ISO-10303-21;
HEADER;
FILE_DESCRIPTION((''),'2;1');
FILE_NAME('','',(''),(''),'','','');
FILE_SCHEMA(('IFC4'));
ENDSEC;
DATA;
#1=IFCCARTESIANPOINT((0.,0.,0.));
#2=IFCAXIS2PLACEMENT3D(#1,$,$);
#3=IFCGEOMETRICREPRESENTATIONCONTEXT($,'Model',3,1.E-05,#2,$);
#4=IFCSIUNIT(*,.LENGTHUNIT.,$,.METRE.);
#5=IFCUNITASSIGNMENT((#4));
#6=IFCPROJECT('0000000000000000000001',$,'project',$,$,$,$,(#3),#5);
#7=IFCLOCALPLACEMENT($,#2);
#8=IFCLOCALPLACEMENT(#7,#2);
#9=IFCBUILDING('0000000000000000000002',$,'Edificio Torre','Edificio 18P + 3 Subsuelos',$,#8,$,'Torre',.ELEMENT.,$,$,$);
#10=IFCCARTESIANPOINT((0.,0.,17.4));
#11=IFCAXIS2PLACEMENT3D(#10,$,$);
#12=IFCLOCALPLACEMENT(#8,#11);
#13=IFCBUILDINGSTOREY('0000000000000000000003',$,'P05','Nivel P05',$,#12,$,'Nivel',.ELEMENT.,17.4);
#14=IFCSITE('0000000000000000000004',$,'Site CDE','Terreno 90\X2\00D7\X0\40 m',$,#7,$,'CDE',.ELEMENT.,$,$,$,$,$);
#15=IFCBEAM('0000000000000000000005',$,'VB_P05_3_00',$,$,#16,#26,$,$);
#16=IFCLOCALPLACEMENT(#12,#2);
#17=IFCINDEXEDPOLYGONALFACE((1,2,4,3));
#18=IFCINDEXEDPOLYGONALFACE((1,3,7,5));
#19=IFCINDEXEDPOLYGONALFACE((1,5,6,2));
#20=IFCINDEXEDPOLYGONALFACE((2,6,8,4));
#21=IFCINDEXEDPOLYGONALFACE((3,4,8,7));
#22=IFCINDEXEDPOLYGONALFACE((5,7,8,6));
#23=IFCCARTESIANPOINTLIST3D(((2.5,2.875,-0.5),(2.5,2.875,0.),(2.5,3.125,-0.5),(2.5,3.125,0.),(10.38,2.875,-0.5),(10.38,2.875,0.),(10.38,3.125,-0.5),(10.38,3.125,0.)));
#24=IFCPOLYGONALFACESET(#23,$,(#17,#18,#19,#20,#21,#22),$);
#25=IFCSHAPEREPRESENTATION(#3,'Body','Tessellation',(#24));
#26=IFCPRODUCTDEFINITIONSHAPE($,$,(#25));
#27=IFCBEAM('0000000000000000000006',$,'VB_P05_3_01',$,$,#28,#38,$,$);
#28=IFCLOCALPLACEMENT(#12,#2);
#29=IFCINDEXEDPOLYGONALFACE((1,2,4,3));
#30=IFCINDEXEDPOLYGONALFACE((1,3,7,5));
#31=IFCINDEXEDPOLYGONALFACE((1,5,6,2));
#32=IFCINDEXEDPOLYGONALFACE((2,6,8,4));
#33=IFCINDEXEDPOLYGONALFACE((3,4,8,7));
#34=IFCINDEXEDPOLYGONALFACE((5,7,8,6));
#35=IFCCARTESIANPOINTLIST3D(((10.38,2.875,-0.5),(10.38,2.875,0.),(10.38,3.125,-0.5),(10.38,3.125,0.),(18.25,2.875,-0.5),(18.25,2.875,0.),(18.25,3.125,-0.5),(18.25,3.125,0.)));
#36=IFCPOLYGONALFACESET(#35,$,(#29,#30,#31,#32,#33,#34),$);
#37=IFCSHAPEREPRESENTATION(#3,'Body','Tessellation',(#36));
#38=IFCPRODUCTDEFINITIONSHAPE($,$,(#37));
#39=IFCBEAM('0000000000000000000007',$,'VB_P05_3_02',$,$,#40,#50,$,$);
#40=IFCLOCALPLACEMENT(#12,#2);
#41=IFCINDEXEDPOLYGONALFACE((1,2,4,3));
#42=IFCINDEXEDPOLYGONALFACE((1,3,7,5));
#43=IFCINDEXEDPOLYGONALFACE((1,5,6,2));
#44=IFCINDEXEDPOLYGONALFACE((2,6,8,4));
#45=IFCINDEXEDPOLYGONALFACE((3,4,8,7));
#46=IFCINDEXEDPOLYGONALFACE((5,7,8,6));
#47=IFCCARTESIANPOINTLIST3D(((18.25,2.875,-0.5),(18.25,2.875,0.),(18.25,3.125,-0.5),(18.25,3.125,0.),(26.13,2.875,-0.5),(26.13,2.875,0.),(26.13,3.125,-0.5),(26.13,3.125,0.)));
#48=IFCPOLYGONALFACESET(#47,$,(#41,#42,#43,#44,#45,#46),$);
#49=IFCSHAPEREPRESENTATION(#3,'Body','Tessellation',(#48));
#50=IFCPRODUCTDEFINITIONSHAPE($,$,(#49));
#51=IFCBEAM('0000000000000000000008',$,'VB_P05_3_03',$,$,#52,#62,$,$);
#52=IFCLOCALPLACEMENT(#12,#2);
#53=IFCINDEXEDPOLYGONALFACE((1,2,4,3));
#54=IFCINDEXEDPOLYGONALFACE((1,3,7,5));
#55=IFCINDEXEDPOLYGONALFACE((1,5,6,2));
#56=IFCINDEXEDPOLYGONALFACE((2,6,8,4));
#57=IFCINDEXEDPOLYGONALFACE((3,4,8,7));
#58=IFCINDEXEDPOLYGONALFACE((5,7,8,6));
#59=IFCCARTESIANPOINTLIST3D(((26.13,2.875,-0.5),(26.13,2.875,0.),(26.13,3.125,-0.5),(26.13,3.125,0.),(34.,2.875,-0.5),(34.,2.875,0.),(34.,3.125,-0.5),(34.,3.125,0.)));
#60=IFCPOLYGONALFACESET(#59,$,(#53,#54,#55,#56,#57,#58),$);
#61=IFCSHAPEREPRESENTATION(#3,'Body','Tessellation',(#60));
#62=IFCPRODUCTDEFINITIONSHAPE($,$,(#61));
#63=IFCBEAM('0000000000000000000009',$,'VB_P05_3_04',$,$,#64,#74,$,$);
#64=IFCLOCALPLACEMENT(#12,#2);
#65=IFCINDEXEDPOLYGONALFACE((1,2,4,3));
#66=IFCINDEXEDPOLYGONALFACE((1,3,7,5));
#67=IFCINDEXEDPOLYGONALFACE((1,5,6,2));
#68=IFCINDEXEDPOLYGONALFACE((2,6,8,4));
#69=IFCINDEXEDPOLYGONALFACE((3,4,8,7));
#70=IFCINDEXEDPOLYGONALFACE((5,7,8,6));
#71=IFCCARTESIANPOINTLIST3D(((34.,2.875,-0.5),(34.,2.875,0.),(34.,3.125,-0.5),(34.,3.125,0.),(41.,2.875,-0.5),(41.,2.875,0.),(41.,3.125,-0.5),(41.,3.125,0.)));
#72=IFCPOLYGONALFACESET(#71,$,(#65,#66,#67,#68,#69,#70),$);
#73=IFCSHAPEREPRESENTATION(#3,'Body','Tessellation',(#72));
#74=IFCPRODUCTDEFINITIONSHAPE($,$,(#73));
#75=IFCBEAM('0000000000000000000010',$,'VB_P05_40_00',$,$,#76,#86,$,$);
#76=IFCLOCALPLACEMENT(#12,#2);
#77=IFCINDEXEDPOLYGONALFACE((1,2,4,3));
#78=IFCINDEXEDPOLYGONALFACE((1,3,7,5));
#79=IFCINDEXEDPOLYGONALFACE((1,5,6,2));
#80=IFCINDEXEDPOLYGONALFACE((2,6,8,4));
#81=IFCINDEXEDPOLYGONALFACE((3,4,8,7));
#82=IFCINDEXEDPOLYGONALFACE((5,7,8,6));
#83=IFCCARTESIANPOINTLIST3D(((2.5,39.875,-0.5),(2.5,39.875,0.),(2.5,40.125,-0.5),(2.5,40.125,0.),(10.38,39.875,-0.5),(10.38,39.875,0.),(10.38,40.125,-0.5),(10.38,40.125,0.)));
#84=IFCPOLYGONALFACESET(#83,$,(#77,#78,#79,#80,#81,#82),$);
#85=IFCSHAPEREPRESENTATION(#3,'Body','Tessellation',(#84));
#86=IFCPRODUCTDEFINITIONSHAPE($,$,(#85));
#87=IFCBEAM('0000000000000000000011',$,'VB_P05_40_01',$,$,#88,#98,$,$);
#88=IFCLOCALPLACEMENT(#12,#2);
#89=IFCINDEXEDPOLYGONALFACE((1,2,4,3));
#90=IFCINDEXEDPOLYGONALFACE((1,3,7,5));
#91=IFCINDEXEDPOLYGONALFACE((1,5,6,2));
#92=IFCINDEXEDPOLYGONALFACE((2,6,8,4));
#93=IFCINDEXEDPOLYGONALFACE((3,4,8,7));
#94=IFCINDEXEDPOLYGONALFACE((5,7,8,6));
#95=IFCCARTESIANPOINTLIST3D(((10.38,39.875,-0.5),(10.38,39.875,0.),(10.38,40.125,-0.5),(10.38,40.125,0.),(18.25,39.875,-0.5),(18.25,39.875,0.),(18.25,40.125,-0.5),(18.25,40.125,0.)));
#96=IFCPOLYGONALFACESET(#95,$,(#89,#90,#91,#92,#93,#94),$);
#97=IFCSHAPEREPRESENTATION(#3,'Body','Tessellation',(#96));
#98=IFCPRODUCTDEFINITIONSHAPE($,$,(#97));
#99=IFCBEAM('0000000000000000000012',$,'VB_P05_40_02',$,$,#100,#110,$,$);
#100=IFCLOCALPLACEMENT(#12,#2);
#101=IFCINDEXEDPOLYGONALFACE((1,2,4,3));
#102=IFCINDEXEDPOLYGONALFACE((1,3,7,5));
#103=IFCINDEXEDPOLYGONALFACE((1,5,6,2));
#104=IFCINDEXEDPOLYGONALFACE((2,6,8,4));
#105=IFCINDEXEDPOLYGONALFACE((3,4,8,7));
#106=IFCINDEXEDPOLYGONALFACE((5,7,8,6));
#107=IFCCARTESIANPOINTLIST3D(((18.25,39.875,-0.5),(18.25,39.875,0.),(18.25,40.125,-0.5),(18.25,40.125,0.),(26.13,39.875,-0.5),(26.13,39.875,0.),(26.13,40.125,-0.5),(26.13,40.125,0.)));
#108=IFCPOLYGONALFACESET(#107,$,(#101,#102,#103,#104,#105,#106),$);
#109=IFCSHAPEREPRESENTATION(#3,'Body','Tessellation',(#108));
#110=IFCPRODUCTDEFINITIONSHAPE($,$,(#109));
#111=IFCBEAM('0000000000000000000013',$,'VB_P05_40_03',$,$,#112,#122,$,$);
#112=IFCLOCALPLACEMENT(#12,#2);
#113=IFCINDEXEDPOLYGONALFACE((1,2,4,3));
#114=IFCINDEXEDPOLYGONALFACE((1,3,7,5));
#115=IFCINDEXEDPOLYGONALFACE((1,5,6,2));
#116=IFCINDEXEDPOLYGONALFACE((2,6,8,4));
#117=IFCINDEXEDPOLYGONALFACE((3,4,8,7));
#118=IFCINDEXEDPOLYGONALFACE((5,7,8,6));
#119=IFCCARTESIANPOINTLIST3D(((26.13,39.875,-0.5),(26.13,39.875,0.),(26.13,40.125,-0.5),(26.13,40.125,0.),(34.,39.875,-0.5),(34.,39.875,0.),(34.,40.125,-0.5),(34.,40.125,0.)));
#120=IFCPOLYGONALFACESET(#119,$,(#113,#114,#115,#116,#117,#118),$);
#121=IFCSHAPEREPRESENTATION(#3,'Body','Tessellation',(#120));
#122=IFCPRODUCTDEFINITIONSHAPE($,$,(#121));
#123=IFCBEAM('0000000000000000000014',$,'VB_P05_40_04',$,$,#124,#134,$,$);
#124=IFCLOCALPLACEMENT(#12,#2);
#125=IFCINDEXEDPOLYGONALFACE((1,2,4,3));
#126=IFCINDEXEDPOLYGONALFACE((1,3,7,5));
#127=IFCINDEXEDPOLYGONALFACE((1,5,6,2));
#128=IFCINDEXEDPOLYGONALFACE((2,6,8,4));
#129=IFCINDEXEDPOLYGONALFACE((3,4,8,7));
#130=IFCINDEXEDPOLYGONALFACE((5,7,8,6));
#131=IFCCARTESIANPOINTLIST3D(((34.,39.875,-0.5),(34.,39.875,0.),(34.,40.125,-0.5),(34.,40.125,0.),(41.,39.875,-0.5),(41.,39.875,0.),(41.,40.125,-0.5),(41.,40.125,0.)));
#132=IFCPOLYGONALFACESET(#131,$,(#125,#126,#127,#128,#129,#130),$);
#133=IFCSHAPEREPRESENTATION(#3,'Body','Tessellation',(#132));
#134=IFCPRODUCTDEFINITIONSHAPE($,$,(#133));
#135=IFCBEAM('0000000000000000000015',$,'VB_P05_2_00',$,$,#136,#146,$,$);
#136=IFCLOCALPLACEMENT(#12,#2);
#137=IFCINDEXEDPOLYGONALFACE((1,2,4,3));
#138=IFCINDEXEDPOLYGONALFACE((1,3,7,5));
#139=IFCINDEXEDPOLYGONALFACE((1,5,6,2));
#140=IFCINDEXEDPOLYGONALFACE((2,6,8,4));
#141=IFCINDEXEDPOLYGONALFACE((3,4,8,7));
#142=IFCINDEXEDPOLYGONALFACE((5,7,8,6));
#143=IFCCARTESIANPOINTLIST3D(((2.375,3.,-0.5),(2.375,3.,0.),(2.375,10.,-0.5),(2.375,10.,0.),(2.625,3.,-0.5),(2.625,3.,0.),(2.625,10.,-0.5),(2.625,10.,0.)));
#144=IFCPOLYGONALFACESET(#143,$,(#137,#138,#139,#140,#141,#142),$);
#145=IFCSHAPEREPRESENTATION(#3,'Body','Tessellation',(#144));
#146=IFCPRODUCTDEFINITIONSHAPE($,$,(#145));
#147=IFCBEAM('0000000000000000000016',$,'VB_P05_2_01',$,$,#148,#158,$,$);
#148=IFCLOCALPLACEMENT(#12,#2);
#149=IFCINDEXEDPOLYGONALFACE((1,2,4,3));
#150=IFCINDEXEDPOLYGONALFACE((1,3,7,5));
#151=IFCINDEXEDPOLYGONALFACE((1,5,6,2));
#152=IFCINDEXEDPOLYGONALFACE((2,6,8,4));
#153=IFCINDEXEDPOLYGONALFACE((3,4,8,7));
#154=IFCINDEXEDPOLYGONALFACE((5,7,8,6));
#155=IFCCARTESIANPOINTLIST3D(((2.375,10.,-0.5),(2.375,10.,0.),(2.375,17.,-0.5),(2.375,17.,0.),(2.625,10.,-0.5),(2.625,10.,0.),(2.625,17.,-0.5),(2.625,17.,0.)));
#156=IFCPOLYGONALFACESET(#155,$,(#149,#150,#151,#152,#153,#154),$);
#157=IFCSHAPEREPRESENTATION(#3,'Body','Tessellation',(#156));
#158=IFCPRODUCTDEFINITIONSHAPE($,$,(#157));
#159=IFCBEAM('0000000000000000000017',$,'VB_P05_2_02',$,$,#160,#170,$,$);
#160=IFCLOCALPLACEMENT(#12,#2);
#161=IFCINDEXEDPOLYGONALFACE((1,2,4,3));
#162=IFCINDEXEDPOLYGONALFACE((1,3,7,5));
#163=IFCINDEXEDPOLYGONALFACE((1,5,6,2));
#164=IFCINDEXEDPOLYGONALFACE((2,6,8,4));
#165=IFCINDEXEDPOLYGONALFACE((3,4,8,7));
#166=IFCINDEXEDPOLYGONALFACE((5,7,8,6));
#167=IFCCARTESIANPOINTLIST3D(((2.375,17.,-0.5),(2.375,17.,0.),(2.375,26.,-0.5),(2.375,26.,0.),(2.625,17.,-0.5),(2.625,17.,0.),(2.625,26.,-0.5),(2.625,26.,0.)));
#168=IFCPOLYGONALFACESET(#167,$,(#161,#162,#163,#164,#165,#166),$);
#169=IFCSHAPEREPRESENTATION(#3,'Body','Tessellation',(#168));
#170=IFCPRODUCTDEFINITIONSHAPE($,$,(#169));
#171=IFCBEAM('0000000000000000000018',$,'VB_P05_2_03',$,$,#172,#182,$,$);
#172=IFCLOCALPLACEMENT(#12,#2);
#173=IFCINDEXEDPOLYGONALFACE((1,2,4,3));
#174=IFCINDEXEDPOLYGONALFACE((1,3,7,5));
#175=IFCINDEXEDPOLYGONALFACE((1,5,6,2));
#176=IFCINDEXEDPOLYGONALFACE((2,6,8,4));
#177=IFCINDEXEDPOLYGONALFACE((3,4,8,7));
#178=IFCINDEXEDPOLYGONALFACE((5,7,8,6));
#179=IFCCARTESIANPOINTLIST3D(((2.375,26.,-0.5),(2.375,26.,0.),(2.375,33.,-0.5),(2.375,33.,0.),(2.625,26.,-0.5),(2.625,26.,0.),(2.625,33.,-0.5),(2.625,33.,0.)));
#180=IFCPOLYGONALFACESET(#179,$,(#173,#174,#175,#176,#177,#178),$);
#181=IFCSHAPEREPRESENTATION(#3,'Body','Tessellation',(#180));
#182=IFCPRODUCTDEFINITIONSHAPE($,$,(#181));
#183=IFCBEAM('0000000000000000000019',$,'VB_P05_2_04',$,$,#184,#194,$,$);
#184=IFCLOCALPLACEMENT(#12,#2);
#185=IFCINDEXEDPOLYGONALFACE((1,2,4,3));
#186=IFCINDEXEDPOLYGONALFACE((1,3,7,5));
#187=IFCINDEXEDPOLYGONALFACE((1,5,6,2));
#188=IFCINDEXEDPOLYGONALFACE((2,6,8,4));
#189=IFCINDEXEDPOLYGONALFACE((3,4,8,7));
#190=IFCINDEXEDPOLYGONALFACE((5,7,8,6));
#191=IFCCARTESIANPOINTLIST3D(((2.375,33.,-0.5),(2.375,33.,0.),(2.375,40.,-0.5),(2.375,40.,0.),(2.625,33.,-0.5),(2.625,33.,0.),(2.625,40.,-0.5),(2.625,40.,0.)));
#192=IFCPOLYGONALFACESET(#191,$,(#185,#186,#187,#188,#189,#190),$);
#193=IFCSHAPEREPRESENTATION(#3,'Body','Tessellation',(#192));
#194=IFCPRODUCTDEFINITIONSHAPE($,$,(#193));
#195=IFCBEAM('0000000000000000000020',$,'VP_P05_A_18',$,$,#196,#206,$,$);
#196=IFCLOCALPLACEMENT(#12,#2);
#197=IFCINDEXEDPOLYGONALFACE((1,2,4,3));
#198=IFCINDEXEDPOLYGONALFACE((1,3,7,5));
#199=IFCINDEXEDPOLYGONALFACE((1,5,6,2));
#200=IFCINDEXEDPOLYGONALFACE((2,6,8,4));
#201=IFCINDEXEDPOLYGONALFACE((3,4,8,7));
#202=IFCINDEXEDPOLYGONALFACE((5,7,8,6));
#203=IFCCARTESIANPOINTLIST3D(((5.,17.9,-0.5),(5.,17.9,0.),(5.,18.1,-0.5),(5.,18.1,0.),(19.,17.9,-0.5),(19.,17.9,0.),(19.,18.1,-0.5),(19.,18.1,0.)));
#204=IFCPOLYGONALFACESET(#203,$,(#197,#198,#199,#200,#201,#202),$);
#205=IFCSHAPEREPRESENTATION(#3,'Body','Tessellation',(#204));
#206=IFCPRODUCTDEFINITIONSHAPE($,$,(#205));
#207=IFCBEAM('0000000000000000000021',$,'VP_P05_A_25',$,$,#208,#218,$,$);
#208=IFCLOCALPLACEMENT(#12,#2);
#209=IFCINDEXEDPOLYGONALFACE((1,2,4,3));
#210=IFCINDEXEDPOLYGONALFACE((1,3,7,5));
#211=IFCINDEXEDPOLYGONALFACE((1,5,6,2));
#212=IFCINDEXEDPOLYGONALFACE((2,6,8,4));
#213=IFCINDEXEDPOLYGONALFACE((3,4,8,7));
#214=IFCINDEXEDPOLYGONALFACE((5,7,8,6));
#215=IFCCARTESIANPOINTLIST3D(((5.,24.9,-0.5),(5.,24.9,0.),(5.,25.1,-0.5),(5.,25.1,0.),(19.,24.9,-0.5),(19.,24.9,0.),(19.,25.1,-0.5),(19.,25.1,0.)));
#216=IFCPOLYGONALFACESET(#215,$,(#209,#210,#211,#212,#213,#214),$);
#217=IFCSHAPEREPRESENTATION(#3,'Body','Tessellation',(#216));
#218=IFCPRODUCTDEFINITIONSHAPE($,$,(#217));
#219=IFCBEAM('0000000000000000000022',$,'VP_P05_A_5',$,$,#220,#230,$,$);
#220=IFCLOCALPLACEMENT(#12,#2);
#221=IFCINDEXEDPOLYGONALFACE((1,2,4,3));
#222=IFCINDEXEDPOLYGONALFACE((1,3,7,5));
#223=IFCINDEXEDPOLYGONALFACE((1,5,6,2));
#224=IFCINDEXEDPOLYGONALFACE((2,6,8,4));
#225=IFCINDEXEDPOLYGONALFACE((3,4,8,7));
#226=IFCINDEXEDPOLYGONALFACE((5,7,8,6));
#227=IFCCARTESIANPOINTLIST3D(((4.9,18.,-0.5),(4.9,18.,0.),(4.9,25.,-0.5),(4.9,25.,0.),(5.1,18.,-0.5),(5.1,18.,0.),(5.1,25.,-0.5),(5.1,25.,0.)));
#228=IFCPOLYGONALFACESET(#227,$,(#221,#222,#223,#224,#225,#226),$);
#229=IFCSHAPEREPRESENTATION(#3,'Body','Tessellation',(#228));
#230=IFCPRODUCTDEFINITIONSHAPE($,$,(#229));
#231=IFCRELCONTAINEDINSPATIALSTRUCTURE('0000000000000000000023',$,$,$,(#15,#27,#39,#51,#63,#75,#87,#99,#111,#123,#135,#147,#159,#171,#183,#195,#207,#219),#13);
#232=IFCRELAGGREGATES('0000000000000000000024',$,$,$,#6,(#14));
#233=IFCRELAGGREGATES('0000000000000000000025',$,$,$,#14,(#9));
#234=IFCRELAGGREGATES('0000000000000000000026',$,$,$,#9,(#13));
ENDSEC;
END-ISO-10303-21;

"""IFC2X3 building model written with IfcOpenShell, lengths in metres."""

from ifc_helpers import new_model, si_unit, frame, origin, origin_2d, place, context, project, spatial, rectangle, extrude, element, save


model = new_model("IFC2X3")

# Units and contexts
model_context = context("Model", 3, precision=1e-05, world=origin())
ifc_project = project(units=[si_unit("LENGTHUNIT", "METRE")], contexts=[model_context])

# Site, building, storey
site_placement = place(None, origin())
site = spatial("IfcSite", under=ifc_project, at=site_placement, Name="Site CDE", Description="Terreno 90×40 m", LongName="CDE", CompositionType="ELEMENT")
building_placement = place(site_placement, origin())
building = spatial("IfcBuilding", under=site, at=building_placement, Name="Edificio Torre", Description="Edificio 18P + 3 Subsuelos", LongName="Torre", CompositionType="ELEMENT")
storey_placement = place(building_placement, frame((0.0, 0.0, 17.4)))
storey = spatial("IfcBuildingStorey", under=building, at=storey_placement, Name="P05", Description="Nivel P05", LongName="Nivel", CompositionType="ELEMENT", Elevation=17.4)

# Beams
beam_1_placement = place(storey_placement, frame((6.44, 3.0, -0.5)))
element("IfcBeam", 1, at=beam_1_placement, inside=storey, Name="VB_P05_3_00", context=model_context, shape_type="SweptSolid", body=[
    extrude(rectangle(XDim=7.88, YDim=0.25, at=origin_2d()), origin(), (0.0, 0.0, 1.0), 0.5),
])
beam_2_placement = place(storey_placement, frame((14.315, 3.0, -0.5)))
element("IfcBeam", 2, at=beam_2_placement, inside=storey, Name="VB_P05_3_01", context=model_context, shape_type="SweptSolid", body=[
    extrude(rectangle(XDim=7.87, YDim=0.25, at=origin_2d()), origin(), (0.0, 0.0, 1.0), 0.5),
])
beam_3_placement = place(storey_placement, frame((22.19, 3.0, -0.5)))
element("IfcBeam", 3, at=beam_3_placement, inside=storey, Name="VB_P05_3_02", context=model_context, shape_type="SweptSolid", body=[
    extrude(rectangle(XDim=7.88, YDim=0.25, at=origin_2d()), origin(), (0.0, 0.0, 1.0), 0.5),
])
beam_4_placement = place(storey_placement, frame((30.065, 3.0, -0.5)))
element("IfcBeam", 4, at=beam_4_placement, inside=storey, Name="VB_P05_3_03", context=model_context, shape_type="SweptSolid", body=[
    extrude(rectangle(XDim=7.87, YDim=0.25, at=origin_2d()), origin(), (0.0, 0.0, 1.0), 0.5),
])
beam_5_placement = place(storey_placement, frame((37.5, 3.0, -0.5)))
element("IfcBeam", 5, at=beam_5_placement, inside=storey, Name="VB_P05_3_04", context=model_context, shape_type="SweptSolid", body=[
    extrude(rectangle(XDim=7.0, YDim=0.25, at=origin_2d()), origin(), (0.0, 0.0, 1.0), 0.5),
])
beam_6_placement = place(storey_placement, frame((6.44, 40.0, -0.5)))
element("IfcBeam", 6, at=beam_6_placement, inside=storey, Name="VB_P05_40_00", context=model_context, shape_type="SweptSolid", body=[
    extrude(rectangle(XDim=7.88, YDim=0.25, at=origin_2d()), origin(), (0.0, 0.0, 1.0), 0.5),
])
beam_7_placement = place(storey_placement, frame((14.315, 40.0, -0.5)))
element("IfcBeam", 7, at=beam_7_placement, inside=storey, Name="VB_P05_40_01", context=model_context, shape_type="SweptSolid", body=[
    extrude(rectangle(XDim=7.87, YDim=0.25, at=origin_2d()), origin(), (0.0, 0.0, 1.0), 0.5),
])
beam_8_placement = place(storey_placement, frame((22.19, 40.0, -0.5)))
element("IfcBeam", 8, at=beam_8_placement, inside=storey, Name="VB_P05_40_02", context=model_context, shape_type="SweptSolid", body=[
    extrude(rectangle(XDim=7.88, YDim=0.25, at=origin_2d()), origin(), (0.0, 0.0, 1.0), 0.5),
])
beam_9_placement = place(storey_placement, frame((30.065, 40.0, -0.5)))
element("IfcBeam", 9, at=beam_9_placement, inside=storey, Name="VB_P05_40_03", context=model_context, shape_type="SweptSolid", body=[
    extrude(rectangle(XDim=7.87, YDim=0.25, at=origin_2d()), origin(), (0.0, 0.0, 1.0), 0.5),
])
beam_10_placement = place(storey_placement, frame((37.5, 40.0, -0.5)))
element("IfcBeam", 10, at=beam_10_placement, inside=storey, Name="VB_P05_40_04", context=model_context, shape_type="SweptSolid", body=[
    extrude(rectangle(XDim=7.0, YDim=0.25, at=origin_2d()), origin(), (0.0, 0.0, 1.0), 0.5),
])
for number, where, name in (
    (11, (2.5, 6.5, -0.5), "VB_P05_2_00"),
    (12, (2.5, 13.5, -0.5), "VB_P05_2_01"),
):
    element("IfcBeam", number, at=place(storey_placement, frame(where)), inside=storey, Name=name, context=model_context, shape_type="SweptSolid", body=[
        extrude(rectangle(XDim=0.25, YDim=7.0, at=origin_2d()), origin(), (0.0, 0.0, 1.0), 0.5),
    ])
beam_11_placement = place(storey_placement, frame((2.5, 21.5, -0.5)))
element("IfcBeam", 13, at=beam_11_placement, inside=storey, Name="VB_P05_2_02", context=model_context, shape_type="SweptSolid", body=[
    extrude(rectangle(XDim=0.25, YDim=9.0, at=origin_2d()), origin(), (0.0, 0.0, 1.0), 0.5),
])
for number, where, name in (
    (14, (2.5, 29.5, -0.5), "VB_P05_2_03"),
    (15, (2.5, 36.5, -0.5), "VB_P05_2_04"),
):
    element("IfcBeam", number, at=place(storey_placement, frame(where)), inside=storey, Name=name, context=model_context, shape_type="SweptSolid", body=[
        extrude(rectangle(XDim=0.25, YDim=7.0, at=origin_2d()), origin(), (0.0, 0.0, 1.0), 0.5),
    ])
for number, where, name in (
    (16, (12.0, 18.0, -0.5), "VP_P05_A_18"),
    (17, (12.0, 25.0, -0.5), "VP_P05_A_25"),
):
    element("IfcBeam", number, at=place(storey_placement, frame(where)), inside=storey, Name=name, context=model_context, shape_type="SweptSolid", body=[
        extrude(rectangle(XDim=14.0, YDim=0.2, at=origin_2d()), origin(), (0.0, 0.0, 1.0), 0.5),
    ])
beam_12_placement = place(storey_placement, frame((5.0, 21.5, -0.5)))
element("IfcBeam", 18, at=beam_12_placement, inside=storey, Name="VP_P05_A_5", context=model_context, shape_type="SweptSolid", body=[
    extrude(rectangle(XDim=0.2, YDim=7.0, at=origin_2d()), origin(), (0.0, 0.0, 1.0), 0.5),
])

save(model, "model.ifc")
